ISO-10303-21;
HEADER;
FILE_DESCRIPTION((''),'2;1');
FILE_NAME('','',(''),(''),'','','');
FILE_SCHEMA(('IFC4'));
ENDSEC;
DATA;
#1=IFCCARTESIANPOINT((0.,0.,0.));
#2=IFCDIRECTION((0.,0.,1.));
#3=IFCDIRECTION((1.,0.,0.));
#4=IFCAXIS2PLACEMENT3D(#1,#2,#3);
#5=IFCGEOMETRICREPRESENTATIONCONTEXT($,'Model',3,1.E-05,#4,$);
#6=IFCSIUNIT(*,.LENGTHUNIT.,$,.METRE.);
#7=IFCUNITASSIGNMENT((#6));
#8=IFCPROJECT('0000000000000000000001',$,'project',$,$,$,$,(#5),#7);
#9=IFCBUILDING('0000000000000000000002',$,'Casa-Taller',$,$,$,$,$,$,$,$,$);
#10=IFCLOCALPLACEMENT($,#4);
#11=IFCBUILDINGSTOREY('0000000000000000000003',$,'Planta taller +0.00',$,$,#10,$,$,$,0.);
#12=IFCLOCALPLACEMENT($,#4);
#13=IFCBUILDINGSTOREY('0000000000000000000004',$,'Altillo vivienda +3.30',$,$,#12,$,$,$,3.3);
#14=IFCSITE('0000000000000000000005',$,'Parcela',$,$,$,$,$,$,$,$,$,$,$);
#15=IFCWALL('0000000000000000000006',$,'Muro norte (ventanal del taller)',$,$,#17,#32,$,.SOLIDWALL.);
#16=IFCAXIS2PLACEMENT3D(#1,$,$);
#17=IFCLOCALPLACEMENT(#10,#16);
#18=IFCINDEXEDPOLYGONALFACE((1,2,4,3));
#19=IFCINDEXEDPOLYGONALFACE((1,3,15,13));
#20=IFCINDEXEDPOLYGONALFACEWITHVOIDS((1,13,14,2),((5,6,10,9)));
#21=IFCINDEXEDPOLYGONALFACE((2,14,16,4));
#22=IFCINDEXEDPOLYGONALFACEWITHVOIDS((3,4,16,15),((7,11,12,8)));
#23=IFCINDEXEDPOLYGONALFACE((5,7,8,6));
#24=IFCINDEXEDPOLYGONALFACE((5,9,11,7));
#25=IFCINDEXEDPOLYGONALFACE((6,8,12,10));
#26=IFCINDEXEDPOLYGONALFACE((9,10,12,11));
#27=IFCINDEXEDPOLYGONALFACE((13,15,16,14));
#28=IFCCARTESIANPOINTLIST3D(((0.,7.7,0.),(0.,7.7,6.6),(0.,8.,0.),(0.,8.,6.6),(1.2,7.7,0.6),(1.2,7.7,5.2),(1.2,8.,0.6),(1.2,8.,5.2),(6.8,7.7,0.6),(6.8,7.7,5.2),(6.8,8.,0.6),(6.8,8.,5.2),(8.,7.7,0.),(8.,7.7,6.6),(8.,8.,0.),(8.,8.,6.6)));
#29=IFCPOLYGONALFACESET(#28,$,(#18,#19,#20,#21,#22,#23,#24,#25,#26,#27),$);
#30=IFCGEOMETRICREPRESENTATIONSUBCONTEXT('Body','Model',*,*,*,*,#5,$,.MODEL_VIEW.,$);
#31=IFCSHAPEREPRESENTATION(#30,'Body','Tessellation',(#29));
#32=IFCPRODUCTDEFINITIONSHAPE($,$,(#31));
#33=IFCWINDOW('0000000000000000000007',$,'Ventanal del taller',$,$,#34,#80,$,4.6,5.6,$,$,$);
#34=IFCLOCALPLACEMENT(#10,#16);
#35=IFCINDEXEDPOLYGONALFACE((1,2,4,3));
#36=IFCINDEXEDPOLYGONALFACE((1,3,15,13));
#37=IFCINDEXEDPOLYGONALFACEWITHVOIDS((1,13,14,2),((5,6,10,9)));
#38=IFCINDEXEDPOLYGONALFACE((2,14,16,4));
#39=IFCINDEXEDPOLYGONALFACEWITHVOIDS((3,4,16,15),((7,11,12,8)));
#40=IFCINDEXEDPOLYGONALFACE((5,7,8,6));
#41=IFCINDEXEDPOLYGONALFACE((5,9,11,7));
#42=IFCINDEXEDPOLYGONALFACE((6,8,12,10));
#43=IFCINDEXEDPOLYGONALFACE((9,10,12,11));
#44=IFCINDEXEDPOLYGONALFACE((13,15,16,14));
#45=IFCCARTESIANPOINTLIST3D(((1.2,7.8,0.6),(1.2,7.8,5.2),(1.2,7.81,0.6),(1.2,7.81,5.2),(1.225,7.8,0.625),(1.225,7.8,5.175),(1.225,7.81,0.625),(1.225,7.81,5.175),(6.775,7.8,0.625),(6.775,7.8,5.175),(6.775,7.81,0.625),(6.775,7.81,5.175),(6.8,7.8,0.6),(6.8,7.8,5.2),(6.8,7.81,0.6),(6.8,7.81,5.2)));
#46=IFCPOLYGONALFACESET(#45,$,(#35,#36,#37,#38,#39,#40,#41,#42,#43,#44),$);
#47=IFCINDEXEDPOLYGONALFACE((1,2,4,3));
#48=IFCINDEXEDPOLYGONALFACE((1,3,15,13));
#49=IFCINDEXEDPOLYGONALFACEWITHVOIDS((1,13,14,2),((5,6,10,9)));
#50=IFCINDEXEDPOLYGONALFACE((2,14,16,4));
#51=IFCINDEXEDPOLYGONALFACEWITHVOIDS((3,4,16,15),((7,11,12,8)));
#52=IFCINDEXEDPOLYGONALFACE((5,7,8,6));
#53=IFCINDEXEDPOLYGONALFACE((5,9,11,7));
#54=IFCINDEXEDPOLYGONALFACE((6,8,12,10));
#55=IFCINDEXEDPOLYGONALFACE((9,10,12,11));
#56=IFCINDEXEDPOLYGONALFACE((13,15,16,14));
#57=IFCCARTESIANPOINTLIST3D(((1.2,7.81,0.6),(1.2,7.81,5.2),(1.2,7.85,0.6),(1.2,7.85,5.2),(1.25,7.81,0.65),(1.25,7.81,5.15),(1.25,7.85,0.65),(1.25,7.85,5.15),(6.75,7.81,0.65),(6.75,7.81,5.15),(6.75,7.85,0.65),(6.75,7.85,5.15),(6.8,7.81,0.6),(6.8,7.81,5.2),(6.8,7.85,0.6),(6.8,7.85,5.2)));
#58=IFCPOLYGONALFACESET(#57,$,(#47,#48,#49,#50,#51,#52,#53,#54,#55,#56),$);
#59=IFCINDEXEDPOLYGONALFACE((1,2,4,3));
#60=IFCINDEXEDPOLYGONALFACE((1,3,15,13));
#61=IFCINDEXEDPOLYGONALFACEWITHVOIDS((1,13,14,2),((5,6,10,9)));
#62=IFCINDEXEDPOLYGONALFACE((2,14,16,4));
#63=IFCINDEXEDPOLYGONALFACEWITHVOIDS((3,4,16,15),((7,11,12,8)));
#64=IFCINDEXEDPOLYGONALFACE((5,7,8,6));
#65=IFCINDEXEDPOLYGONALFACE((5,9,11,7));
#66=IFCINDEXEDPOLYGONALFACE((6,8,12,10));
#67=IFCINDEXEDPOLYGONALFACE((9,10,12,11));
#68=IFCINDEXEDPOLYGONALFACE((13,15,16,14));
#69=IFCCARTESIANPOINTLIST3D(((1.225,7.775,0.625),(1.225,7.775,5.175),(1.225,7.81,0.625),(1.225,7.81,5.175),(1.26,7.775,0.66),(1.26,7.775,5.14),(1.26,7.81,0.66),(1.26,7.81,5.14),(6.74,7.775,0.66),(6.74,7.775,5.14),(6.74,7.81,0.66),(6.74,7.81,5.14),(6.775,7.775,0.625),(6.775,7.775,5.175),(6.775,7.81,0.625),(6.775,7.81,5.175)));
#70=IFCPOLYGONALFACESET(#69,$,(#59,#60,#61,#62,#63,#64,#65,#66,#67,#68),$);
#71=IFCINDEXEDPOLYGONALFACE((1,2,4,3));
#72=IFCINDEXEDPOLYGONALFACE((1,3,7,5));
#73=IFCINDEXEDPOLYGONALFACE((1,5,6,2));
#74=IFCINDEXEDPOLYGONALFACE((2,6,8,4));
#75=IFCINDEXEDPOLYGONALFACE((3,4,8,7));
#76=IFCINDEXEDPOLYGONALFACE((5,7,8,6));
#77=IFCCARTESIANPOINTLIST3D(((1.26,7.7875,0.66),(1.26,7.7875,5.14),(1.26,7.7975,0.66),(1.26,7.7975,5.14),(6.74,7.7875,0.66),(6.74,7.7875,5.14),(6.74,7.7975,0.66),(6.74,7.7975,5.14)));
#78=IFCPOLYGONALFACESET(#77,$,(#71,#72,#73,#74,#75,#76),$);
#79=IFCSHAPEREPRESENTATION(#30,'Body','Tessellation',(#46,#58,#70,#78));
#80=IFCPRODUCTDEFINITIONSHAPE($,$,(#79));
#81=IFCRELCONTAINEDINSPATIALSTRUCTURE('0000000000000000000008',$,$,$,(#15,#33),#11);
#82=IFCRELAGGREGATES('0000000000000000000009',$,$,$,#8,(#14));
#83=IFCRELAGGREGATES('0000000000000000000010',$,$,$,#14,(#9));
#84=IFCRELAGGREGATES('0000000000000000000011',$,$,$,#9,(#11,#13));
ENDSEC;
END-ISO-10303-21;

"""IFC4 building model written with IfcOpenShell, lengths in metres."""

from ifc_helpers import new_model, si_unit, frame, origin_with_axes, place, context, subcontext, project, spatial, line, indexed_curve, outline, extrude, element, fill, save


model = new_model("IFC4")

# Units and contexts
model_context = context("Model", 3, precision=1e-05, world=origin_with_axes())
body_context = subcontext(model_context, "Body", "Model", "MODEL_VIEW")
ifc_project = project(units=[si_unit("LENGTHUNIT", "METRE")], contexts=[model_context])

# Site, building, storey
site = spatial("IfcSite", under=ifc_project, Name="Parcela")
building = spatial("IfcBuilding", under=site, Name="Casa-Taller")
storey_1_placement = place(None, origin_with_axes())
storey_1 = spatial("IfcBuildingStorey", under=building, at=storey_1_placement, Name="Planta taller +0.00", Elevation=0.0)

# Shared definitions
storey_2_placement = place(None, origin_with_axes())
storey_2 = spatial("IfcBuildingStorey", under=building, at=storey_2_placement, Name="Altillo vivienda +3.30", Elevation=3.3)

# Wall, opening, window
wall_1_placement = place(storey_1_placement, frame((8.0, 8.0, 0.0), z_axis=(0.0, 0.0, 1.0), x_axis=(-1.0, 0.0, 0.0)))
wall_1 = element("IfcWall", 1, at=wall_1_placement, inside=storey_1, Name="Muro norte (ventanal del taller)", PredefinedType="SOLIDWALL", context=body_context, shape_type="SweptSolid", body=[
    extrude(outline(indexed_curve([(0.0, 0.0), (0.0, 0.3), (8.0, 0.3), (8.0, 0.0), (0.0, 0.0)], self_intersect=False)), origin_with_axes(), (0.0, 0.0, 1.0), 6.6),
])
opening_1_placement = place(wall_1_placement, frame((1.2, -0.1, 0.6), z_axis=(0.0, 0.0, 1.0), x_axis=(1.0, 0.0, 0.0)))
opening_1 = element("IfcOpeningElement", 2, at=opening_1_placement, cuts=wall_1, context=body_context, shape_type="SweptSolid", body=[
    extrude(outline(indexed_curve([(0.0, 0.0), (0.0, 0.5), (5.6, 0.5), (5.6, 0.0), (0.0, 0.0)], self_intersect=False)), origin_with_axes(), (0.0, 0.0, 1.0), 4.6),
])
window_1_placement = place(opening_1_placement, frame((0.0, 0.2, 0.0), z_axis=(0.0, 0.0, 1.0), x_axis=(1.0, 0.0, 0.0)))
window_1 = element("IfcWindow", 3, at=window_1_placement, inside=storey_1, Name="Ventanal del taller", OverallHeight=4.6, OverallWidth=5.6, context=body_context, shape_type="SweptSolid", body=[
    extrude(outline(indexed_curve([(0.0, 0.0), (5.6, 0.0), (5.6, 4.6), (0.0, 4.6)], segments=[line(1, 2, 3, 4, 1)]), holes=[indexed_curve([(0.025, 0.025), (5.575, 0.025), (5.575, 4.575), (0.025, 4.575)], segments=[line(1, 2, 3, 4, 1)])]), frame((0.0, 0.09, 0.0), z_axis=(0.0, -1.0, 0.0), x_axis=(1.0, 0.0, 0.0)), (0.0, 0.0, -1.0), 0.01),
    extrude(outline(indexed_curve([(0.0, 0.0), (5.6, 0.0), (5.6, 4.6), (0.0, 4.6)], segments=[line(1, 2, 3, 4, 1)]), holes=[indexed_curve([(0.05, 0.05), (5.55, 0.05), (5.55, 4.55), (0.05, 4.55)], segments=[line(1, 2, 3, 4, 1)])]), frame((0.0, 0.05, 0.0), z_axis=(0.0, -1.0, 0.0), x_axis=(1.0, 0.0, 0.0)), (0.0, 0.0, -1.0), 0.04),
    extrude(outline(indexed_curve([(0.0, 0.0), (5.55, 0.0), (5.55, 4.55), (0.0, 4.55)], segments=[line(1, 2, 3, 4, 1)]), holes=[indexed_curve([(0.035, 0.035), (5.515, 0.035), (5.515, 4.515), (0.035, 4.515)], segments=[line(1, 2, 3, 4, 1)])]), frame((0.025, 0.09, 0.025), z_axis=(0.0, -1.0, 0.0), x_axis=(1.0, 0.0, 0.0)), (0.0, 0.0, -1.0), 0.035),
    extrude(outline(indexed_curve([(0.035, 0.035), (5.515, 0.035), (5.515, 4.515), (0.035, 4.515)], segments=[line(1, 2, 3, 4, 1)])), frame((0.025, 0.1025, 0.025), z_axis=(0.0, -1.0, 0.0), x_axis=(1.0, 0.0, 0.0)), (0.0, 0.0, -1.0), 0.01),
])
fill(opening_1, window_1)

save(model, "model.ifc")
